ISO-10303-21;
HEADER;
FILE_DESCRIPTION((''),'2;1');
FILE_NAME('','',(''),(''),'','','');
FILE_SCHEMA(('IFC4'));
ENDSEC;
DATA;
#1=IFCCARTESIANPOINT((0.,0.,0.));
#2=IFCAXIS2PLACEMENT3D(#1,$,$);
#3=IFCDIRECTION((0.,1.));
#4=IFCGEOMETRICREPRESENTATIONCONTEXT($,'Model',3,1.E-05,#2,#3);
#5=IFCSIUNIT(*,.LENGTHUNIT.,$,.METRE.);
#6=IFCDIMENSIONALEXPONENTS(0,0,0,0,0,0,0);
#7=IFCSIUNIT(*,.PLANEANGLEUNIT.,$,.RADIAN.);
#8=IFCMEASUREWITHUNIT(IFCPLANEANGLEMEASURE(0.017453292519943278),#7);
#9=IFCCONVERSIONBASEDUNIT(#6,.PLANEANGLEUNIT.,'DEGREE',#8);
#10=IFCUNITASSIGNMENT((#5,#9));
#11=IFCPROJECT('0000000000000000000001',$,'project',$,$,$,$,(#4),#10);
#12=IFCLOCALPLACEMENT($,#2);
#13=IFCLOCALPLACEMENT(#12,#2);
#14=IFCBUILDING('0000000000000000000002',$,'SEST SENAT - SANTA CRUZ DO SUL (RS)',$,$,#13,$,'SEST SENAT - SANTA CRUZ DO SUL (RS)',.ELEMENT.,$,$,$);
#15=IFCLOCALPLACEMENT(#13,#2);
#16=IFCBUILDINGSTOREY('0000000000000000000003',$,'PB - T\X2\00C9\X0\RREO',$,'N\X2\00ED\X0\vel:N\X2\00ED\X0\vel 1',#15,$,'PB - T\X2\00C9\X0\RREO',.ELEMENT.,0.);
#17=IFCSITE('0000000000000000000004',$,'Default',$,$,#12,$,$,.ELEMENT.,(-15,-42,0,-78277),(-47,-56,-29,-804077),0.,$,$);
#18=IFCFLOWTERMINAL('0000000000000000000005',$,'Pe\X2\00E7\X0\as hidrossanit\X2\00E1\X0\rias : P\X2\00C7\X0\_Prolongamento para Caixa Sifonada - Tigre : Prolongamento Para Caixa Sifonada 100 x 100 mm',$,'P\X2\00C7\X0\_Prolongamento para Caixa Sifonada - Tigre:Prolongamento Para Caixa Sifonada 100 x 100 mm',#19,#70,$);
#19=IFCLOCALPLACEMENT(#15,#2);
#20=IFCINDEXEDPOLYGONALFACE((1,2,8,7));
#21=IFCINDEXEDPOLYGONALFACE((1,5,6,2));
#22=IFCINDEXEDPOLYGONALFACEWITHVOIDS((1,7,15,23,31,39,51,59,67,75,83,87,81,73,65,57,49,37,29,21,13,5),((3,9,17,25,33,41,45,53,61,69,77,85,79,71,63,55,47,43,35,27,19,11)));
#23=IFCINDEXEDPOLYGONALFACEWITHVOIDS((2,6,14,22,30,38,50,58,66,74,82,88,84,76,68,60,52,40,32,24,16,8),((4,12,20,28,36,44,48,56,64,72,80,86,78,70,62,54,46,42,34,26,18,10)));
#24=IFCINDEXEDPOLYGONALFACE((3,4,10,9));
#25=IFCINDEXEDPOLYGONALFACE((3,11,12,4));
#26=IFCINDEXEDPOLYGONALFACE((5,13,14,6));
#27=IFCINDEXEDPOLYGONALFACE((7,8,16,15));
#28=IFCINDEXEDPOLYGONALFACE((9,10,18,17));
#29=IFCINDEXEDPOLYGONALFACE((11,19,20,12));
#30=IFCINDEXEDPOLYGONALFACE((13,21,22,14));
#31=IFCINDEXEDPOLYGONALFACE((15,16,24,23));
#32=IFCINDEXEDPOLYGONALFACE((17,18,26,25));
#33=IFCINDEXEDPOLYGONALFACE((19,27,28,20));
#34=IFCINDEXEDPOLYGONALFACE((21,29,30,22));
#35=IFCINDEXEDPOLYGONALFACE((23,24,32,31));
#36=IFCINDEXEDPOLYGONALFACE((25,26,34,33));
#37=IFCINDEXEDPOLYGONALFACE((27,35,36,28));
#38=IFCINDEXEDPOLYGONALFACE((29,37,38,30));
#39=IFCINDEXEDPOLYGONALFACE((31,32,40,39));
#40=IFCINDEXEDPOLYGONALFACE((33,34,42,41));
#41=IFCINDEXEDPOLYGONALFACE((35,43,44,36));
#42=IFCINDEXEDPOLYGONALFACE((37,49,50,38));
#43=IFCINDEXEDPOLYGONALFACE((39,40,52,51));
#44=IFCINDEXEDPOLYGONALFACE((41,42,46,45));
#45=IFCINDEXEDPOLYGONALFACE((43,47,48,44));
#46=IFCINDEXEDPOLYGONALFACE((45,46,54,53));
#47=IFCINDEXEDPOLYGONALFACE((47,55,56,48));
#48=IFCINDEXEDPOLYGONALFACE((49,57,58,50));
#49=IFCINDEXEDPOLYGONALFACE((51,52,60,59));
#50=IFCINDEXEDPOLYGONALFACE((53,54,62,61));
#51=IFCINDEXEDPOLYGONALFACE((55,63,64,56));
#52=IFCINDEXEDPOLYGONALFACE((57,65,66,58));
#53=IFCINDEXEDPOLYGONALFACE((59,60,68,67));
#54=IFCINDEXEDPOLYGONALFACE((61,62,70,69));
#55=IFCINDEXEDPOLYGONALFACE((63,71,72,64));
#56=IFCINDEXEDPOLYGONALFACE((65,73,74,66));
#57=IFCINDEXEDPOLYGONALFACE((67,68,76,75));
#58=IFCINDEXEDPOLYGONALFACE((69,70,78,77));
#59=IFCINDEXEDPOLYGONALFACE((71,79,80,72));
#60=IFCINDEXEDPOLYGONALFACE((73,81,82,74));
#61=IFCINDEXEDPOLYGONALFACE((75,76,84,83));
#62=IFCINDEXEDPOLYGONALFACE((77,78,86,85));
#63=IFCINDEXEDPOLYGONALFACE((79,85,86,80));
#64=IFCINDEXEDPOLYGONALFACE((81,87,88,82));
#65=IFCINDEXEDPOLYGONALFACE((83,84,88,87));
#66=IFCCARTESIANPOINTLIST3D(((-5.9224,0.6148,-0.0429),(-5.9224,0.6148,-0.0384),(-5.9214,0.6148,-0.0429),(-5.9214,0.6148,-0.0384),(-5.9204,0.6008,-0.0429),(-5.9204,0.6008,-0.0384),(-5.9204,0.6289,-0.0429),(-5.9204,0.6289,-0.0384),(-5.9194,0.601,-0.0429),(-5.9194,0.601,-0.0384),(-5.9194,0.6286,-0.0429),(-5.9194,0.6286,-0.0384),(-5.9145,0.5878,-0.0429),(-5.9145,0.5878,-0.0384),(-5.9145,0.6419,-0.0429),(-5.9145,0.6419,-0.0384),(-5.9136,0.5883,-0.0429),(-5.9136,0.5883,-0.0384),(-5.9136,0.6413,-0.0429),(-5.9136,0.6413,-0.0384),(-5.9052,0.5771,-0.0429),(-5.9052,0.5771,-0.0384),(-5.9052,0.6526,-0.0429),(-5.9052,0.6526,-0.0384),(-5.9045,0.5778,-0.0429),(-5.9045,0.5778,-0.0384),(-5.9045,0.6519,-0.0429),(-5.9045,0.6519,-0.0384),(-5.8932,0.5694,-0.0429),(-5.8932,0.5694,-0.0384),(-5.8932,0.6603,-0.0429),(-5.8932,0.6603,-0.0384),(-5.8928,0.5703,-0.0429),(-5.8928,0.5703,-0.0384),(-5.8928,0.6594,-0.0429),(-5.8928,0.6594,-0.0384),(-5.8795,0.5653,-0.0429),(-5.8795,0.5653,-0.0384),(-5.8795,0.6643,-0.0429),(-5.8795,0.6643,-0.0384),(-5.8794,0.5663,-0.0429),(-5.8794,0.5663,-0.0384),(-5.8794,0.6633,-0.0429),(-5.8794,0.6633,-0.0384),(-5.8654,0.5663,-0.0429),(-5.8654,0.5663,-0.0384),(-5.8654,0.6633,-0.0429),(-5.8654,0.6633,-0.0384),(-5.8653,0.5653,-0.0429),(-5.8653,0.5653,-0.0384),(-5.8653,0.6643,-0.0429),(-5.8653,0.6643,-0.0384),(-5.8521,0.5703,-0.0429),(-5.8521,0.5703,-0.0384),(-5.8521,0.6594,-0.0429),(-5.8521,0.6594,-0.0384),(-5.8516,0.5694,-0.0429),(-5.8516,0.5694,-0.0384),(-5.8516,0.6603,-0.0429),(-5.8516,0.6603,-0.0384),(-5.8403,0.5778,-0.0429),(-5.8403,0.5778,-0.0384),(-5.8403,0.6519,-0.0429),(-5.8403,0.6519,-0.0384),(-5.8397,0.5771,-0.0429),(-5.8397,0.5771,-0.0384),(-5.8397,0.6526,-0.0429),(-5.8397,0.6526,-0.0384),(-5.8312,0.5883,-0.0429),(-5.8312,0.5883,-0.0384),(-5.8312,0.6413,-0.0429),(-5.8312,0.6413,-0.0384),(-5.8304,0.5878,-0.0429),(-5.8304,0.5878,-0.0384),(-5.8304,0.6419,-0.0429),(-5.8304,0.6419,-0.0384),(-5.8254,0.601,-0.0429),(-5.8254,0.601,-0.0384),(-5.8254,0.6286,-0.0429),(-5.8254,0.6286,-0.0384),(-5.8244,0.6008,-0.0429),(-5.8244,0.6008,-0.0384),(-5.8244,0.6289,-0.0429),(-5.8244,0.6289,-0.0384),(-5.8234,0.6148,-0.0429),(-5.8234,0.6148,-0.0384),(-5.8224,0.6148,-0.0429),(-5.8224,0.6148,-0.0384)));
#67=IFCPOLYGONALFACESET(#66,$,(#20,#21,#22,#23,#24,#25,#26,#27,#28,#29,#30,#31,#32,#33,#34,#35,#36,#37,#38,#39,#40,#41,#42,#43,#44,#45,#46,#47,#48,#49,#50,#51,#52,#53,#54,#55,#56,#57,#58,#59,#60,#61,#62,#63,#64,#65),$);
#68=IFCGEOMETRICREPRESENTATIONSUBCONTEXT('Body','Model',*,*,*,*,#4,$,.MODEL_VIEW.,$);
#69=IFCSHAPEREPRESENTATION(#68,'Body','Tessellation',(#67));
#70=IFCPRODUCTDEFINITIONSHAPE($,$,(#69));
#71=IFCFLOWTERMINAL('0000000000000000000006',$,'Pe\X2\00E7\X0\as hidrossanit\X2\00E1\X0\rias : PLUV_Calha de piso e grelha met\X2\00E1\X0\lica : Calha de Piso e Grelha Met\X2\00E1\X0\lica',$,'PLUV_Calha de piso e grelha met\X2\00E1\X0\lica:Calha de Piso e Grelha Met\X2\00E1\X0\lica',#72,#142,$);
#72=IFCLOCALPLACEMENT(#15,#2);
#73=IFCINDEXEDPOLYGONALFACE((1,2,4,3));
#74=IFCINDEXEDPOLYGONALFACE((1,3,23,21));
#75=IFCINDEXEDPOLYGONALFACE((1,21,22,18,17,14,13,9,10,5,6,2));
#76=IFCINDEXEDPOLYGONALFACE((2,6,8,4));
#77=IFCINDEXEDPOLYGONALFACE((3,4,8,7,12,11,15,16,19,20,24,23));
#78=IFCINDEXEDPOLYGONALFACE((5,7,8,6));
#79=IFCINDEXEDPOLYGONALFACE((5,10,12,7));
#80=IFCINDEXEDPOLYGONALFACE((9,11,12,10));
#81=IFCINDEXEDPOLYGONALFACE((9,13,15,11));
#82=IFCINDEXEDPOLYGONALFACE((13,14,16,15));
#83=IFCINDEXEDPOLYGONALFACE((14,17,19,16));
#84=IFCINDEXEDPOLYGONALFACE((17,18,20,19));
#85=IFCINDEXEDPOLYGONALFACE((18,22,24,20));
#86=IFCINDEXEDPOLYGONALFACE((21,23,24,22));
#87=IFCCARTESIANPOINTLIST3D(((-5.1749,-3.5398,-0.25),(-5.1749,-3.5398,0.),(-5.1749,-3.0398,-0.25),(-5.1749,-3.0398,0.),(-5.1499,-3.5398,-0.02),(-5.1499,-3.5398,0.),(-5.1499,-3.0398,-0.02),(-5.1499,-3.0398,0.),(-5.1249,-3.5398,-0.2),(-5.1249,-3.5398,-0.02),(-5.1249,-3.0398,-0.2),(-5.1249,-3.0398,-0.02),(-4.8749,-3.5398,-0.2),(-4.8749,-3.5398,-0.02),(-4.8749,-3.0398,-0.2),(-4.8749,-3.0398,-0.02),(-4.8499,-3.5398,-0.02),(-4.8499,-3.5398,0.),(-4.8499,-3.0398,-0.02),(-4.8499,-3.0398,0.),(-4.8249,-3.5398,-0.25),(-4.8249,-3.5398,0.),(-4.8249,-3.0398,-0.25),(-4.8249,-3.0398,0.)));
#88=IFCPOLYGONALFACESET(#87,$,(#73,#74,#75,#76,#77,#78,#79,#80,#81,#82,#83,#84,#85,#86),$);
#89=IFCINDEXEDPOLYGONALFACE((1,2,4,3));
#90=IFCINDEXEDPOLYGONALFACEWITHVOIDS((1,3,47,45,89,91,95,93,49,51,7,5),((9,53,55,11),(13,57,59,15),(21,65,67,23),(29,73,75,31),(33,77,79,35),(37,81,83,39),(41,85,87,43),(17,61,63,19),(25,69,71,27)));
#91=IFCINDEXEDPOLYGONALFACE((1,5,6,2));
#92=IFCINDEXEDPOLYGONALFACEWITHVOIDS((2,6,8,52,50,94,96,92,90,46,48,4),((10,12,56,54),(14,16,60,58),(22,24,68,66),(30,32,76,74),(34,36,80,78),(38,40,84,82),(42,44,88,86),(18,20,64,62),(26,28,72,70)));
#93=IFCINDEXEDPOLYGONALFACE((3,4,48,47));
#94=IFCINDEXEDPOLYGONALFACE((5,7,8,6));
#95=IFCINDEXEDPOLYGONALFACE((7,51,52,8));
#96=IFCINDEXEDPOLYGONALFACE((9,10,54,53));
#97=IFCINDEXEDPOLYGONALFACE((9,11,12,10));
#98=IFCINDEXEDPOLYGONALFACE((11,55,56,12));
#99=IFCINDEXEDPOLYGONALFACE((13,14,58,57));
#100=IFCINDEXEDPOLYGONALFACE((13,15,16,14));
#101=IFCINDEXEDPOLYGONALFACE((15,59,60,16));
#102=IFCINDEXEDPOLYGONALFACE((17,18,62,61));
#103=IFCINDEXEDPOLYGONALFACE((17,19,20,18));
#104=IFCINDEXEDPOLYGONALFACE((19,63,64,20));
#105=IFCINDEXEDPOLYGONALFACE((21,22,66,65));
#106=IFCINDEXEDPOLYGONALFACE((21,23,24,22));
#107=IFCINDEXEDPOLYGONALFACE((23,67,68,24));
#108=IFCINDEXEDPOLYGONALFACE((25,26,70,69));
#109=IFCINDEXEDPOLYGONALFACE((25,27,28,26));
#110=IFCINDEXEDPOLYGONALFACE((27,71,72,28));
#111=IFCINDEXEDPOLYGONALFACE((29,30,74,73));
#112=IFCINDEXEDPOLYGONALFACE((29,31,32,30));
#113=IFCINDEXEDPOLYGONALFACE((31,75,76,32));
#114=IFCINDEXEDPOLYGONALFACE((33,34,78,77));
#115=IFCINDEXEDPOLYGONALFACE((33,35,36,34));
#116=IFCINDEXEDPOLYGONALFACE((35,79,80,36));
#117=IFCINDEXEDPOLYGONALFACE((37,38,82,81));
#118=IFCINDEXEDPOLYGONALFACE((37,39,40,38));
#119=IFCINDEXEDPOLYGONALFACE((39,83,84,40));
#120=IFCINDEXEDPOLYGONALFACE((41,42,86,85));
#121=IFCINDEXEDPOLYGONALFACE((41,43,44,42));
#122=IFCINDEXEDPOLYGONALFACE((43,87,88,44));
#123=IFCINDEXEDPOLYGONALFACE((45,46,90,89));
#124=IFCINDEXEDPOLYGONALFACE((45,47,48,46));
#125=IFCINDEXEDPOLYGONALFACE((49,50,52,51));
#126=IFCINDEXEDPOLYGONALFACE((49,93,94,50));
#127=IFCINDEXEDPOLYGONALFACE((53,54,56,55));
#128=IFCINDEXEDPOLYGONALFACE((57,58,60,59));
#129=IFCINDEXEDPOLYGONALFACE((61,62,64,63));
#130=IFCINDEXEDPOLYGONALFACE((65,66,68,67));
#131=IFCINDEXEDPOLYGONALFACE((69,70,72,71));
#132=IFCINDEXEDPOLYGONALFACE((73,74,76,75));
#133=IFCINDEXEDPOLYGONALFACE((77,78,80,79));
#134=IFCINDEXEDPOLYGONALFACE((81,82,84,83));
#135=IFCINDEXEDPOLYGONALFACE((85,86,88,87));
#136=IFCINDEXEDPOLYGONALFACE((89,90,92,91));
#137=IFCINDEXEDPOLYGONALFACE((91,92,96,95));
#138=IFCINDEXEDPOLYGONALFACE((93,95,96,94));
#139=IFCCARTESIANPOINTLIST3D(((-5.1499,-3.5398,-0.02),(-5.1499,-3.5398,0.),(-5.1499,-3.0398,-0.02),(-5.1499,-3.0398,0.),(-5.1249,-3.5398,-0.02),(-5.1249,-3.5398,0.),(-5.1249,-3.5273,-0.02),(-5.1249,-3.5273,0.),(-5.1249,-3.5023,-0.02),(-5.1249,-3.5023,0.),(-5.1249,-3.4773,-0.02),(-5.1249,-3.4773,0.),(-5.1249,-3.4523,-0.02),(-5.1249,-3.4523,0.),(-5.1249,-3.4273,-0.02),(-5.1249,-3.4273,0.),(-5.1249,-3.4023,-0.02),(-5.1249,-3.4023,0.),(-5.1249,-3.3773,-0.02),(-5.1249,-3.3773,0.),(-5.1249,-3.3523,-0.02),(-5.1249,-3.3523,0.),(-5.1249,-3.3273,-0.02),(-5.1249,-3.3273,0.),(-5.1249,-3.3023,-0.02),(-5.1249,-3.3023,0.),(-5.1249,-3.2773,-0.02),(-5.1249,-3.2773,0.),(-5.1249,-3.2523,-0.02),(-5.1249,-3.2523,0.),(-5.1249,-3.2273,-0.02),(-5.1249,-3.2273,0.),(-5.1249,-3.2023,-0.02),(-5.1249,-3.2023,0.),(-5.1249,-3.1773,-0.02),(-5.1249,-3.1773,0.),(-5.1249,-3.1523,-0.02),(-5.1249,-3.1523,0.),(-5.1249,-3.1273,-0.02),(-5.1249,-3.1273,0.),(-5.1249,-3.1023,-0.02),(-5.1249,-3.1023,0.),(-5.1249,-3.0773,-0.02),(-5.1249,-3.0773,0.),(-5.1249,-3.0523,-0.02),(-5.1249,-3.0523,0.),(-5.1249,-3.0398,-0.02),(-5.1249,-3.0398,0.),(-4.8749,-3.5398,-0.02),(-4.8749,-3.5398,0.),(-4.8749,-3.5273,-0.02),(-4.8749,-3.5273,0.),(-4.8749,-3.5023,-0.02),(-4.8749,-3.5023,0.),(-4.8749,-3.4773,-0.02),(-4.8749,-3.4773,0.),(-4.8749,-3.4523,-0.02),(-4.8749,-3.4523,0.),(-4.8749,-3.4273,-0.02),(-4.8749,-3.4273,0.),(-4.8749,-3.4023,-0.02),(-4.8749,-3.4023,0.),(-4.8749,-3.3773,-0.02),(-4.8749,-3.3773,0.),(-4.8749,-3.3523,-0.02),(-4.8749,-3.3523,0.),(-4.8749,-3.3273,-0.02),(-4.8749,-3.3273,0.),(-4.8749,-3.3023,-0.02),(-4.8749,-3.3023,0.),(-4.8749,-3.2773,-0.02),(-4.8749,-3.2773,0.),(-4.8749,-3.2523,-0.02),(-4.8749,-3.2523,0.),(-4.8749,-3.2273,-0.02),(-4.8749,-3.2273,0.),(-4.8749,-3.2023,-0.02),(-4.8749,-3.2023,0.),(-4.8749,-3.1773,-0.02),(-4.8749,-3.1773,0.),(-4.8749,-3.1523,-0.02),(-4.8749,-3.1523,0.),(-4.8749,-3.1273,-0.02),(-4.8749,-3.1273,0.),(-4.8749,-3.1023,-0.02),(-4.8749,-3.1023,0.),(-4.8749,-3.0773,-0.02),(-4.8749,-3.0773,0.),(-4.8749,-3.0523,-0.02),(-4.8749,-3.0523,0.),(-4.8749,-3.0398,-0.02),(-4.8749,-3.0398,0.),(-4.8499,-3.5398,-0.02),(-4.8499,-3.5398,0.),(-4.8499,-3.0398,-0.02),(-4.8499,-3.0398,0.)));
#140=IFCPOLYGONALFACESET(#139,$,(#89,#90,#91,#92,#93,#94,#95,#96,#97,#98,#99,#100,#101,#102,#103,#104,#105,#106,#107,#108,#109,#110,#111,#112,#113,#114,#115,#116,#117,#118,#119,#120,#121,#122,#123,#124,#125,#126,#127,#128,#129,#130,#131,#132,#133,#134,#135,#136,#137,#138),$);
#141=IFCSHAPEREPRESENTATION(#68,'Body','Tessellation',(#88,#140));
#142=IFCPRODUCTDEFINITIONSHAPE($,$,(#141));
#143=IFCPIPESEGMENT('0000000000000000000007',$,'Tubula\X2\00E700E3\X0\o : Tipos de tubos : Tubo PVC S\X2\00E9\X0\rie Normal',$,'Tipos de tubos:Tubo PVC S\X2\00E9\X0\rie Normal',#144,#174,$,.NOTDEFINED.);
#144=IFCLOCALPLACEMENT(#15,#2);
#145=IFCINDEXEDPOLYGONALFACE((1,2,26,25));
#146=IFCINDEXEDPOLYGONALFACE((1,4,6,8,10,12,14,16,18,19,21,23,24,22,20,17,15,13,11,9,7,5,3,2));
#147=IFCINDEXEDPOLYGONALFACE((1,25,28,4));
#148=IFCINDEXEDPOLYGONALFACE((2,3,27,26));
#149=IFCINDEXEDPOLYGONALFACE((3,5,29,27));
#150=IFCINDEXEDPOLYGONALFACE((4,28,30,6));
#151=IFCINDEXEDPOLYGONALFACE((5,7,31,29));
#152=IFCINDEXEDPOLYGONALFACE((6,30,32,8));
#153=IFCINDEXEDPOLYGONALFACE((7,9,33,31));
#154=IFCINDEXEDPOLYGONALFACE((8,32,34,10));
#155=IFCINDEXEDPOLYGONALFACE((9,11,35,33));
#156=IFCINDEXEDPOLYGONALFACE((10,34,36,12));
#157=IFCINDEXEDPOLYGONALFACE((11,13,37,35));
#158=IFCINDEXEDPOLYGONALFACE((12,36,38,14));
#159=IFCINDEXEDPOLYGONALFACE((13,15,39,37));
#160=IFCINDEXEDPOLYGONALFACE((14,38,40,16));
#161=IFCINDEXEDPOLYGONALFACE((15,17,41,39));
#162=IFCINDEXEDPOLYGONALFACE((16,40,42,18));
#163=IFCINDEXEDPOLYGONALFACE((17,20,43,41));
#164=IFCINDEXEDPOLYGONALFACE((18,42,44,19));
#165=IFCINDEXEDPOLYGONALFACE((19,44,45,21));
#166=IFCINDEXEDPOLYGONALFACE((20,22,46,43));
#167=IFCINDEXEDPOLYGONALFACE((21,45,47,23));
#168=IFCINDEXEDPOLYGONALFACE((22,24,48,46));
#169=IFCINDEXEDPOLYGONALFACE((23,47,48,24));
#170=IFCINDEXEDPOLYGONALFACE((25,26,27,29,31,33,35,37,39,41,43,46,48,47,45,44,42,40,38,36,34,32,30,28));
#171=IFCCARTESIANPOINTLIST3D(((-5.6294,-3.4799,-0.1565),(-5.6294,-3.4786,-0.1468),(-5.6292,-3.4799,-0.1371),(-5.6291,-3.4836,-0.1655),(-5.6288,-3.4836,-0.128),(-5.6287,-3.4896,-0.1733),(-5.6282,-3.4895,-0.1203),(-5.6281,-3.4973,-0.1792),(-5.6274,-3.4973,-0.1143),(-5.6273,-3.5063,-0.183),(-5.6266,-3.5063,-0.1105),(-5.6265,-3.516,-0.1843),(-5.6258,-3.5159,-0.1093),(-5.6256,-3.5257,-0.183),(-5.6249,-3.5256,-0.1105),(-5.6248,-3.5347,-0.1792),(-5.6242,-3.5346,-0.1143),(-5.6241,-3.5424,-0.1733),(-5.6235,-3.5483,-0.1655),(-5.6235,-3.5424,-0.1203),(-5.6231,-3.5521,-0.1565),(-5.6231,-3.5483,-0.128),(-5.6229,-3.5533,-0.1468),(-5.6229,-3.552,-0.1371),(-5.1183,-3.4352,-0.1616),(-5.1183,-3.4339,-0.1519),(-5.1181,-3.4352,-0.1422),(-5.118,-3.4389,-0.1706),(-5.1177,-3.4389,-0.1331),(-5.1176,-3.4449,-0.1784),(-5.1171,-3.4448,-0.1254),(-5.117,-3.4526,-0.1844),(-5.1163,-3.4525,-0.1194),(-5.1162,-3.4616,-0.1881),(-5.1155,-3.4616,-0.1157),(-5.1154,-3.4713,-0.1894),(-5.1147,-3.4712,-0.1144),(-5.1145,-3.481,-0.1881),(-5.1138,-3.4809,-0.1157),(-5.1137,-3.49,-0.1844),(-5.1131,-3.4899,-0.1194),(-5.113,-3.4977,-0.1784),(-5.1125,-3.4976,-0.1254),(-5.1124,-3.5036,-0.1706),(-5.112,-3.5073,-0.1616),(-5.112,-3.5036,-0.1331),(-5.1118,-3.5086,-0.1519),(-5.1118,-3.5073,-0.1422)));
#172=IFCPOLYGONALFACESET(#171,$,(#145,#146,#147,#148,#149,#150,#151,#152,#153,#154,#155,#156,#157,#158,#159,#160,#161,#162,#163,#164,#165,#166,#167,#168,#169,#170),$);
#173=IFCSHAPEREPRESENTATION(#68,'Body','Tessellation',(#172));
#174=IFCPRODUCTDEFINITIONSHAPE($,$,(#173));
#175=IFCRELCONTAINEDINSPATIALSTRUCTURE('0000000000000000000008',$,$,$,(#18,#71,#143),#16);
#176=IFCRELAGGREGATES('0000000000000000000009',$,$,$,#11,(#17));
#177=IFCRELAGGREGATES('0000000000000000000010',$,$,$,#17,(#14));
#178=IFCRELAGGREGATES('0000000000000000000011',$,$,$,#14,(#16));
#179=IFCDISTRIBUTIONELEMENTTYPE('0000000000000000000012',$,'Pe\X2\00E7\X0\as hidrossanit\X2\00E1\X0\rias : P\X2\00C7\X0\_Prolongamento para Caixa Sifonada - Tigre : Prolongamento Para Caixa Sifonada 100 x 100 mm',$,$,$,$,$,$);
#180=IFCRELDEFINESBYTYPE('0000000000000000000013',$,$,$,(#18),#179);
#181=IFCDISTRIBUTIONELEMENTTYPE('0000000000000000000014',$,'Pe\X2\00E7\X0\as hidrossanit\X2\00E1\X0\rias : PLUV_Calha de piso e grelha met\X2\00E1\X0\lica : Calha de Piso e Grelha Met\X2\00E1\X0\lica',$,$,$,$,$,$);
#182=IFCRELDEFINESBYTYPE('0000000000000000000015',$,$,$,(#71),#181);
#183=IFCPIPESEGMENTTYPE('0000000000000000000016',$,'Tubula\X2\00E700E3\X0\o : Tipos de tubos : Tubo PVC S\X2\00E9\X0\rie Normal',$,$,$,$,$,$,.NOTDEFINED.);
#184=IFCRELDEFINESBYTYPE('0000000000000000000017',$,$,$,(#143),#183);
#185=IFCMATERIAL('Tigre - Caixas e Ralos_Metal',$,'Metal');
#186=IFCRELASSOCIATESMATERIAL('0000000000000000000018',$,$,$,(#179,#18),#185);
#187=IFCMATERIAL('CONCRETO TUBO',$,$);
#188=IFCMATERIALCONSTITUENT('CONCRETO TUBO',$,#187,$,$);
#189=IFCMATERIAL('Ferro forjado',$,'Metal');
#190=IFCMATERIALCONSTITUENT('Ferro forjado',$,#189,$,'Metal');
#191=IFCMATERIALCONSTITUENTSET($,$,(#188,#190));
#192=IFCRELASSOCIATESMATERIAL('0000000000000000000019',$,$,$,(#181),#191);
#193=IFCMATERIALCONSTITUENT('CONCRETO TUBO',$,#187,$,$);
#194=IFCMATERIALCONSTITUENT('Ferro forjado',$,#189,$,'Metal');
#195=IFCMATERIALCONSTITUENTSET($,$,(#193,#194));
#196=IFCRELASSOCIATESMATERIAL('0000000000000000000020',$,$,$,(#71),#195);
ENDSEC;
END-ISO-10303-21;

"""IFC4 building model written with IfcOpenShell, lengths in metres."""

from ifc_helpers import new_model, entity, si_unit, converted_unit, direction, frame, origin, place, context, subcontext, project, spatial, arc, indexed_curve, outline, extrude, source, transform, mapped, material, constituent, constituent_set, type_object, type_shapes, element, save


model = new_model("IFC4")

# Units and contexts
model_context = context("Model", 3, precision=1e-05, world=origin(), true_north=direction((0.0, 1.0)))
body_context = subcontext(model_context, "Body", "Model", "MODEL_VIEW")
ifc_project = project(units=[si_unit("LENGTHUNIT", "METRE"), converted_unit("PLANEANGLEUNIT", "DEGREE", entity("IfcPlaneAngleMeasure", 0.017453292519943278), si_unit("PLANEANGLEUNIT", "RADIAN"), dimensions=[0, 0, 0, 0, 0, 0, 0])], contexts=[model_context])

# Site, building, storey
site_placement = place(None, origin())
site = spatial("IfcSite", under=ifc_project, at=site_placement, Name="Default", CompositionType="ELEMENT", RefLatitude=(-15, -42, 0, -78277), RefLongitude=(-47, -56, -29, -804077), RefElevation=0.0)
building_placement = place(site_placement, origin())
building = spatial("IfcBuilding", under=site, at=building_placement, Name="SEST SENAT - SANTA CRUZ DO SUL (RS)", LongName="SEST SENAT - SANTA CRUZ DO SUL (RS)", CompositionType="ELEMENT")
storey_placement = place(building_placement, origin())
storey = spatial("IfcBuildingStorey", under=building, at=storey_placement, Name="PB - TÉRREO", ObjectType="Nível:Nível 1", LongName="PB - TÉRREO", CompositionType="ELEMENT", Elevation=0.0)

# Flow terminals
ifc_material_1 = material(Name="Tigre - Caixas e Ralos_Metal", Category="Metal")
distribution_element_type_1 = type_object("IfcDistributionElementType", Name="Peças hidrossanitárias : PÇ_Prolongamento para Caixa Sifonada - Tigre : Prolongamento Para Caixa Sifonada 100 x 100 mm", material=ifc_material_1)
shared_shape_1 = source(origin(), body_context, "Body", "SweptSolid", [
    extrude(outline(indexed_curve([(-0.05, 0.0), (0.0, -0.05), (0.05, 0.0), (0.0, 0.05)], segments=[arc(1, 2, 3), arc(3, 4, 1)], self_intersect=False), holes=[indexed_curve([(-0.049, 0.0), (0.0, 0.049), (0.049, 0.0), (0.0, -0.049)], segments=[arc(1, 2, 3), arc(3, 4, 1)], self_intersect=False)]), frame((0.0, 0.0, -0.0045)), (0.0, 0.0, 1.0), 0.0045),
])
type_shapes(distribution_element_type_1, [shared_shape_1])
flow_terminal_1_placement = place(storey_placement, frame((-5.8724, 0.6148, -0.0384)))
element("IfcFlowTerminal", 1, at=flow_terminal_1_placement, inside=storey, type_object=distribution_element_type_1, material=ifc_material_1, Name="Peças hidrossanitárias : PÇ_Prolongamento para Caixa Sifonada - Tigre : Prolongamento Para Caixa Sifonada 100 x 100 mm", ObjectType="PÇ_Prolongamento para Caixa Sifonada - Tigre:Prolongamento Para Caixa Sifonada 100 x 100 mm", context=body_context, shape_type="MappedRepresentation", body=[
    mapped(shared_shape_1, transform((0.0, 0.0, 0.0), scale=1.0)),
])
ifc_material_2 = material(Name="CONCRETO TUBO")
ifc_constituent_1 = constituent(ifc_material_2, Name="CONCRETO TUBO")
ifc_material_3 = material(Name="Ferro forjado", Category="Metal")
ifc_constituent_2 = constituent(ifc_material_3, Name="Ferro forjado", Category="Metal")
ifc_constituent_set_1 = constituent_set(constituents=[ifc_constituent_1, ifc_constituent_2])
ifc_constituent_3 = constituent(ifc_material_2, Name="CONCRETO TUBO")
ifc_constituent_4 = constituent(ifc_material_3, Name="Ferro forjado", Category="Metal")
ifc_constituent_set_2 = constituent_set(constituents=[ifc_constituent_3, ifc_constituent_4])
distribution_element_type_2 = type_object("IfcDistributionElementType", Name="Peças hidrossanitárias : PLUV_Calha de piso e grelha metálica : Calha de Piso e Grelha Metálica", material=ifc_constituent_set_2)
shared_shape_2 = source(origin(), body_context, "Body", "SweptSolid", [
    extrude(outline(indexed_curve([(-0.175, -0.0817), (-0.15, -0.0817), (-0.15, -0.0617), (-0.125, -0.0617), (-0.125, 0.1183), (0.125, 0.1183), (0.125, -0.0617), (0.15, -0.0617), (0.15, -0.0817), (0.175, -0.0817), (0.175, 0.1683), (-0.175, 0.1683), (-0.175, -0.0817)], self_intersect=False)), frame((-0.25, 0.0, -0.0817), z_axis=(1.0, 0.0, 0.0), x_axis=(0.0, -1.0, 0.0)), (0.0, 0.0, 1.0), 0.5),
    extrude(outline(indexed_curve([(0.125, -0.25), (0.15, -0.25), (0.15, 0.25), (0.125, 0.25), (0.125, 0.2375), (-0.125, 0.2375), (-0.125, 0.25), (-0.15, 0.25), (-0.15, -0.25), (-0.125, -0.25), (-0.125, -0.2375), (0.125, -0.2375), (0.125, -0.25)], self_intersect=False), holes=[indexed_curve([(0.125, 0.2125), (0.125, 0.1875), (-0.125, 0.1875), (-0.125, 0.2125), (0.125, 0.2125)], self_intersect=False), indexed_curve([(0.125, 0.1625), (0.125, 0.1375), (-0.125, 0.1375), (-0.125, 0.1625), (0.125, 0.1625)], self_intersect=False), indexed_curve([(0.125, 0.1125), (0.125, 0.0875), (-0.125, 0.0875), (-0.125, 0.1125), (0.125, 0.1125)], self_intersect=False), indexed_curve([(0.125, 0.0625), (0.125, 0.0375), (-0.125, 0.0375), (-0.125, 0.0625), (0.125, 0.0625)], self_intersect=False), indexed_curve([(0.125, 0.0125), (0.125, -0.0125), (-0.125, -0.0125), (-0.125, 0.0125), (0.125, 0.0125)], self_intersect=False), indexed_curve([(0.125, -0.0375), (0.125, -0.0625), (-0.125, -0.0625), (-0.125, -0.0375), (0.125, -0.0375)], self_intersect=False), indexed_curve([(0.125, -0.0875), (0.125, -0.1125), (-0.125, -0.1125), (-0.125, -0.0875), (0.125, -0.0875)], self_intersect=False), indexed_curve([(0.125, -0.1375), (0.125, -0.1625), (-0.125, -0.1625), (-0.125, -0.1375), (0.125, -0.1375)], self_intersect=False), indexed_curve([(0.125, -0.1875), (0.125, -0.2125), (-0.125, -0.2125), (-0.125, -0.1875), (0.125, -0.1875)], self_intersect=False)]), frame((0.0, 0.0, -0.02), z_axis=(0.0, 0.0, 1.0), x_axis=(0.0, 1.0, 0.0)), (0.0, 0.0, 1.0), 0.02),
])
type_shapes(distribution_element_type_2, [shared_shape_2])
flow_terminal_2_placement = place(storey_placement, frame((-4.9999, -3.2898, 0.0), z_axis=(0.0, 0.0, 1.0), x_axis=(0.0, -1.0, 0.0)))
element("IfcFlowTerminal", 2, at=flow_terminal_2_placement, inside=storey, type_object=distribution_element_type_2, material=ifc_constituent_set_1, Name="Peças hidrossanitárias : PLUV_Calha de piso e grelha metálica : Calha de Piso e Grelha Metálica", ObjectType="PLUV_Calha de piso e grelha metálica:Calha de Piso e Grelha Metálica", context=body_context, shape_type="MappedRepresentation", body=[
    mapped(shared_shape_2, transform((0.0, 0.0, 0.0), scale=1.0)),
])

# Pipe segment
pipe_segment_type_1 = type_object("IfcPipeSegmentType", Name="Tubulação : Tipos de tubos : Tubo PVC Série Normal", PredefinedType="NOTDEFINED")
pipe_segment_1_placement = place(storey_placement, frame((-5.631, -3.5549, -0.1077)))
element("IfcPipeSegment", 3, at=pipe_segment_1_placement, inside=storey, type_object=pipe_segment_type_1, Name="Tubulação : Tipos de tubos : Tubo PVC Série Normal", ObjectType="Tipos de tubos:Tubo PVC Série Normal", PredefinedType="NOTDEFINED", context=body_context, shape_type="SweptSolid", body=[
    extrude(outline(indexed_curve([(0.0375, 0.0), (0.0265, 0.0265), (0.0, 0.0375), (-0.0265, 0.0265), (-0.0375, 0.0), (-0.0265, -0.0265), (0.0, -0.0375), (0.0265, -0.0265)], segments=[arc(1, 2, 3), arc(3, 4, 5), arc(5, 6, 7), arc(7, 8, 1)], self_intersect=False)), frame((0.516, 0.0837, -0.0442), z_axis=(-0.996145, -0.087156, 0.009961), x_axis=(0.08716, -0.996194, 0.0)), (0.0, 0.0, 1.0), 0.5131),
])

save(model, "model.ifc")
